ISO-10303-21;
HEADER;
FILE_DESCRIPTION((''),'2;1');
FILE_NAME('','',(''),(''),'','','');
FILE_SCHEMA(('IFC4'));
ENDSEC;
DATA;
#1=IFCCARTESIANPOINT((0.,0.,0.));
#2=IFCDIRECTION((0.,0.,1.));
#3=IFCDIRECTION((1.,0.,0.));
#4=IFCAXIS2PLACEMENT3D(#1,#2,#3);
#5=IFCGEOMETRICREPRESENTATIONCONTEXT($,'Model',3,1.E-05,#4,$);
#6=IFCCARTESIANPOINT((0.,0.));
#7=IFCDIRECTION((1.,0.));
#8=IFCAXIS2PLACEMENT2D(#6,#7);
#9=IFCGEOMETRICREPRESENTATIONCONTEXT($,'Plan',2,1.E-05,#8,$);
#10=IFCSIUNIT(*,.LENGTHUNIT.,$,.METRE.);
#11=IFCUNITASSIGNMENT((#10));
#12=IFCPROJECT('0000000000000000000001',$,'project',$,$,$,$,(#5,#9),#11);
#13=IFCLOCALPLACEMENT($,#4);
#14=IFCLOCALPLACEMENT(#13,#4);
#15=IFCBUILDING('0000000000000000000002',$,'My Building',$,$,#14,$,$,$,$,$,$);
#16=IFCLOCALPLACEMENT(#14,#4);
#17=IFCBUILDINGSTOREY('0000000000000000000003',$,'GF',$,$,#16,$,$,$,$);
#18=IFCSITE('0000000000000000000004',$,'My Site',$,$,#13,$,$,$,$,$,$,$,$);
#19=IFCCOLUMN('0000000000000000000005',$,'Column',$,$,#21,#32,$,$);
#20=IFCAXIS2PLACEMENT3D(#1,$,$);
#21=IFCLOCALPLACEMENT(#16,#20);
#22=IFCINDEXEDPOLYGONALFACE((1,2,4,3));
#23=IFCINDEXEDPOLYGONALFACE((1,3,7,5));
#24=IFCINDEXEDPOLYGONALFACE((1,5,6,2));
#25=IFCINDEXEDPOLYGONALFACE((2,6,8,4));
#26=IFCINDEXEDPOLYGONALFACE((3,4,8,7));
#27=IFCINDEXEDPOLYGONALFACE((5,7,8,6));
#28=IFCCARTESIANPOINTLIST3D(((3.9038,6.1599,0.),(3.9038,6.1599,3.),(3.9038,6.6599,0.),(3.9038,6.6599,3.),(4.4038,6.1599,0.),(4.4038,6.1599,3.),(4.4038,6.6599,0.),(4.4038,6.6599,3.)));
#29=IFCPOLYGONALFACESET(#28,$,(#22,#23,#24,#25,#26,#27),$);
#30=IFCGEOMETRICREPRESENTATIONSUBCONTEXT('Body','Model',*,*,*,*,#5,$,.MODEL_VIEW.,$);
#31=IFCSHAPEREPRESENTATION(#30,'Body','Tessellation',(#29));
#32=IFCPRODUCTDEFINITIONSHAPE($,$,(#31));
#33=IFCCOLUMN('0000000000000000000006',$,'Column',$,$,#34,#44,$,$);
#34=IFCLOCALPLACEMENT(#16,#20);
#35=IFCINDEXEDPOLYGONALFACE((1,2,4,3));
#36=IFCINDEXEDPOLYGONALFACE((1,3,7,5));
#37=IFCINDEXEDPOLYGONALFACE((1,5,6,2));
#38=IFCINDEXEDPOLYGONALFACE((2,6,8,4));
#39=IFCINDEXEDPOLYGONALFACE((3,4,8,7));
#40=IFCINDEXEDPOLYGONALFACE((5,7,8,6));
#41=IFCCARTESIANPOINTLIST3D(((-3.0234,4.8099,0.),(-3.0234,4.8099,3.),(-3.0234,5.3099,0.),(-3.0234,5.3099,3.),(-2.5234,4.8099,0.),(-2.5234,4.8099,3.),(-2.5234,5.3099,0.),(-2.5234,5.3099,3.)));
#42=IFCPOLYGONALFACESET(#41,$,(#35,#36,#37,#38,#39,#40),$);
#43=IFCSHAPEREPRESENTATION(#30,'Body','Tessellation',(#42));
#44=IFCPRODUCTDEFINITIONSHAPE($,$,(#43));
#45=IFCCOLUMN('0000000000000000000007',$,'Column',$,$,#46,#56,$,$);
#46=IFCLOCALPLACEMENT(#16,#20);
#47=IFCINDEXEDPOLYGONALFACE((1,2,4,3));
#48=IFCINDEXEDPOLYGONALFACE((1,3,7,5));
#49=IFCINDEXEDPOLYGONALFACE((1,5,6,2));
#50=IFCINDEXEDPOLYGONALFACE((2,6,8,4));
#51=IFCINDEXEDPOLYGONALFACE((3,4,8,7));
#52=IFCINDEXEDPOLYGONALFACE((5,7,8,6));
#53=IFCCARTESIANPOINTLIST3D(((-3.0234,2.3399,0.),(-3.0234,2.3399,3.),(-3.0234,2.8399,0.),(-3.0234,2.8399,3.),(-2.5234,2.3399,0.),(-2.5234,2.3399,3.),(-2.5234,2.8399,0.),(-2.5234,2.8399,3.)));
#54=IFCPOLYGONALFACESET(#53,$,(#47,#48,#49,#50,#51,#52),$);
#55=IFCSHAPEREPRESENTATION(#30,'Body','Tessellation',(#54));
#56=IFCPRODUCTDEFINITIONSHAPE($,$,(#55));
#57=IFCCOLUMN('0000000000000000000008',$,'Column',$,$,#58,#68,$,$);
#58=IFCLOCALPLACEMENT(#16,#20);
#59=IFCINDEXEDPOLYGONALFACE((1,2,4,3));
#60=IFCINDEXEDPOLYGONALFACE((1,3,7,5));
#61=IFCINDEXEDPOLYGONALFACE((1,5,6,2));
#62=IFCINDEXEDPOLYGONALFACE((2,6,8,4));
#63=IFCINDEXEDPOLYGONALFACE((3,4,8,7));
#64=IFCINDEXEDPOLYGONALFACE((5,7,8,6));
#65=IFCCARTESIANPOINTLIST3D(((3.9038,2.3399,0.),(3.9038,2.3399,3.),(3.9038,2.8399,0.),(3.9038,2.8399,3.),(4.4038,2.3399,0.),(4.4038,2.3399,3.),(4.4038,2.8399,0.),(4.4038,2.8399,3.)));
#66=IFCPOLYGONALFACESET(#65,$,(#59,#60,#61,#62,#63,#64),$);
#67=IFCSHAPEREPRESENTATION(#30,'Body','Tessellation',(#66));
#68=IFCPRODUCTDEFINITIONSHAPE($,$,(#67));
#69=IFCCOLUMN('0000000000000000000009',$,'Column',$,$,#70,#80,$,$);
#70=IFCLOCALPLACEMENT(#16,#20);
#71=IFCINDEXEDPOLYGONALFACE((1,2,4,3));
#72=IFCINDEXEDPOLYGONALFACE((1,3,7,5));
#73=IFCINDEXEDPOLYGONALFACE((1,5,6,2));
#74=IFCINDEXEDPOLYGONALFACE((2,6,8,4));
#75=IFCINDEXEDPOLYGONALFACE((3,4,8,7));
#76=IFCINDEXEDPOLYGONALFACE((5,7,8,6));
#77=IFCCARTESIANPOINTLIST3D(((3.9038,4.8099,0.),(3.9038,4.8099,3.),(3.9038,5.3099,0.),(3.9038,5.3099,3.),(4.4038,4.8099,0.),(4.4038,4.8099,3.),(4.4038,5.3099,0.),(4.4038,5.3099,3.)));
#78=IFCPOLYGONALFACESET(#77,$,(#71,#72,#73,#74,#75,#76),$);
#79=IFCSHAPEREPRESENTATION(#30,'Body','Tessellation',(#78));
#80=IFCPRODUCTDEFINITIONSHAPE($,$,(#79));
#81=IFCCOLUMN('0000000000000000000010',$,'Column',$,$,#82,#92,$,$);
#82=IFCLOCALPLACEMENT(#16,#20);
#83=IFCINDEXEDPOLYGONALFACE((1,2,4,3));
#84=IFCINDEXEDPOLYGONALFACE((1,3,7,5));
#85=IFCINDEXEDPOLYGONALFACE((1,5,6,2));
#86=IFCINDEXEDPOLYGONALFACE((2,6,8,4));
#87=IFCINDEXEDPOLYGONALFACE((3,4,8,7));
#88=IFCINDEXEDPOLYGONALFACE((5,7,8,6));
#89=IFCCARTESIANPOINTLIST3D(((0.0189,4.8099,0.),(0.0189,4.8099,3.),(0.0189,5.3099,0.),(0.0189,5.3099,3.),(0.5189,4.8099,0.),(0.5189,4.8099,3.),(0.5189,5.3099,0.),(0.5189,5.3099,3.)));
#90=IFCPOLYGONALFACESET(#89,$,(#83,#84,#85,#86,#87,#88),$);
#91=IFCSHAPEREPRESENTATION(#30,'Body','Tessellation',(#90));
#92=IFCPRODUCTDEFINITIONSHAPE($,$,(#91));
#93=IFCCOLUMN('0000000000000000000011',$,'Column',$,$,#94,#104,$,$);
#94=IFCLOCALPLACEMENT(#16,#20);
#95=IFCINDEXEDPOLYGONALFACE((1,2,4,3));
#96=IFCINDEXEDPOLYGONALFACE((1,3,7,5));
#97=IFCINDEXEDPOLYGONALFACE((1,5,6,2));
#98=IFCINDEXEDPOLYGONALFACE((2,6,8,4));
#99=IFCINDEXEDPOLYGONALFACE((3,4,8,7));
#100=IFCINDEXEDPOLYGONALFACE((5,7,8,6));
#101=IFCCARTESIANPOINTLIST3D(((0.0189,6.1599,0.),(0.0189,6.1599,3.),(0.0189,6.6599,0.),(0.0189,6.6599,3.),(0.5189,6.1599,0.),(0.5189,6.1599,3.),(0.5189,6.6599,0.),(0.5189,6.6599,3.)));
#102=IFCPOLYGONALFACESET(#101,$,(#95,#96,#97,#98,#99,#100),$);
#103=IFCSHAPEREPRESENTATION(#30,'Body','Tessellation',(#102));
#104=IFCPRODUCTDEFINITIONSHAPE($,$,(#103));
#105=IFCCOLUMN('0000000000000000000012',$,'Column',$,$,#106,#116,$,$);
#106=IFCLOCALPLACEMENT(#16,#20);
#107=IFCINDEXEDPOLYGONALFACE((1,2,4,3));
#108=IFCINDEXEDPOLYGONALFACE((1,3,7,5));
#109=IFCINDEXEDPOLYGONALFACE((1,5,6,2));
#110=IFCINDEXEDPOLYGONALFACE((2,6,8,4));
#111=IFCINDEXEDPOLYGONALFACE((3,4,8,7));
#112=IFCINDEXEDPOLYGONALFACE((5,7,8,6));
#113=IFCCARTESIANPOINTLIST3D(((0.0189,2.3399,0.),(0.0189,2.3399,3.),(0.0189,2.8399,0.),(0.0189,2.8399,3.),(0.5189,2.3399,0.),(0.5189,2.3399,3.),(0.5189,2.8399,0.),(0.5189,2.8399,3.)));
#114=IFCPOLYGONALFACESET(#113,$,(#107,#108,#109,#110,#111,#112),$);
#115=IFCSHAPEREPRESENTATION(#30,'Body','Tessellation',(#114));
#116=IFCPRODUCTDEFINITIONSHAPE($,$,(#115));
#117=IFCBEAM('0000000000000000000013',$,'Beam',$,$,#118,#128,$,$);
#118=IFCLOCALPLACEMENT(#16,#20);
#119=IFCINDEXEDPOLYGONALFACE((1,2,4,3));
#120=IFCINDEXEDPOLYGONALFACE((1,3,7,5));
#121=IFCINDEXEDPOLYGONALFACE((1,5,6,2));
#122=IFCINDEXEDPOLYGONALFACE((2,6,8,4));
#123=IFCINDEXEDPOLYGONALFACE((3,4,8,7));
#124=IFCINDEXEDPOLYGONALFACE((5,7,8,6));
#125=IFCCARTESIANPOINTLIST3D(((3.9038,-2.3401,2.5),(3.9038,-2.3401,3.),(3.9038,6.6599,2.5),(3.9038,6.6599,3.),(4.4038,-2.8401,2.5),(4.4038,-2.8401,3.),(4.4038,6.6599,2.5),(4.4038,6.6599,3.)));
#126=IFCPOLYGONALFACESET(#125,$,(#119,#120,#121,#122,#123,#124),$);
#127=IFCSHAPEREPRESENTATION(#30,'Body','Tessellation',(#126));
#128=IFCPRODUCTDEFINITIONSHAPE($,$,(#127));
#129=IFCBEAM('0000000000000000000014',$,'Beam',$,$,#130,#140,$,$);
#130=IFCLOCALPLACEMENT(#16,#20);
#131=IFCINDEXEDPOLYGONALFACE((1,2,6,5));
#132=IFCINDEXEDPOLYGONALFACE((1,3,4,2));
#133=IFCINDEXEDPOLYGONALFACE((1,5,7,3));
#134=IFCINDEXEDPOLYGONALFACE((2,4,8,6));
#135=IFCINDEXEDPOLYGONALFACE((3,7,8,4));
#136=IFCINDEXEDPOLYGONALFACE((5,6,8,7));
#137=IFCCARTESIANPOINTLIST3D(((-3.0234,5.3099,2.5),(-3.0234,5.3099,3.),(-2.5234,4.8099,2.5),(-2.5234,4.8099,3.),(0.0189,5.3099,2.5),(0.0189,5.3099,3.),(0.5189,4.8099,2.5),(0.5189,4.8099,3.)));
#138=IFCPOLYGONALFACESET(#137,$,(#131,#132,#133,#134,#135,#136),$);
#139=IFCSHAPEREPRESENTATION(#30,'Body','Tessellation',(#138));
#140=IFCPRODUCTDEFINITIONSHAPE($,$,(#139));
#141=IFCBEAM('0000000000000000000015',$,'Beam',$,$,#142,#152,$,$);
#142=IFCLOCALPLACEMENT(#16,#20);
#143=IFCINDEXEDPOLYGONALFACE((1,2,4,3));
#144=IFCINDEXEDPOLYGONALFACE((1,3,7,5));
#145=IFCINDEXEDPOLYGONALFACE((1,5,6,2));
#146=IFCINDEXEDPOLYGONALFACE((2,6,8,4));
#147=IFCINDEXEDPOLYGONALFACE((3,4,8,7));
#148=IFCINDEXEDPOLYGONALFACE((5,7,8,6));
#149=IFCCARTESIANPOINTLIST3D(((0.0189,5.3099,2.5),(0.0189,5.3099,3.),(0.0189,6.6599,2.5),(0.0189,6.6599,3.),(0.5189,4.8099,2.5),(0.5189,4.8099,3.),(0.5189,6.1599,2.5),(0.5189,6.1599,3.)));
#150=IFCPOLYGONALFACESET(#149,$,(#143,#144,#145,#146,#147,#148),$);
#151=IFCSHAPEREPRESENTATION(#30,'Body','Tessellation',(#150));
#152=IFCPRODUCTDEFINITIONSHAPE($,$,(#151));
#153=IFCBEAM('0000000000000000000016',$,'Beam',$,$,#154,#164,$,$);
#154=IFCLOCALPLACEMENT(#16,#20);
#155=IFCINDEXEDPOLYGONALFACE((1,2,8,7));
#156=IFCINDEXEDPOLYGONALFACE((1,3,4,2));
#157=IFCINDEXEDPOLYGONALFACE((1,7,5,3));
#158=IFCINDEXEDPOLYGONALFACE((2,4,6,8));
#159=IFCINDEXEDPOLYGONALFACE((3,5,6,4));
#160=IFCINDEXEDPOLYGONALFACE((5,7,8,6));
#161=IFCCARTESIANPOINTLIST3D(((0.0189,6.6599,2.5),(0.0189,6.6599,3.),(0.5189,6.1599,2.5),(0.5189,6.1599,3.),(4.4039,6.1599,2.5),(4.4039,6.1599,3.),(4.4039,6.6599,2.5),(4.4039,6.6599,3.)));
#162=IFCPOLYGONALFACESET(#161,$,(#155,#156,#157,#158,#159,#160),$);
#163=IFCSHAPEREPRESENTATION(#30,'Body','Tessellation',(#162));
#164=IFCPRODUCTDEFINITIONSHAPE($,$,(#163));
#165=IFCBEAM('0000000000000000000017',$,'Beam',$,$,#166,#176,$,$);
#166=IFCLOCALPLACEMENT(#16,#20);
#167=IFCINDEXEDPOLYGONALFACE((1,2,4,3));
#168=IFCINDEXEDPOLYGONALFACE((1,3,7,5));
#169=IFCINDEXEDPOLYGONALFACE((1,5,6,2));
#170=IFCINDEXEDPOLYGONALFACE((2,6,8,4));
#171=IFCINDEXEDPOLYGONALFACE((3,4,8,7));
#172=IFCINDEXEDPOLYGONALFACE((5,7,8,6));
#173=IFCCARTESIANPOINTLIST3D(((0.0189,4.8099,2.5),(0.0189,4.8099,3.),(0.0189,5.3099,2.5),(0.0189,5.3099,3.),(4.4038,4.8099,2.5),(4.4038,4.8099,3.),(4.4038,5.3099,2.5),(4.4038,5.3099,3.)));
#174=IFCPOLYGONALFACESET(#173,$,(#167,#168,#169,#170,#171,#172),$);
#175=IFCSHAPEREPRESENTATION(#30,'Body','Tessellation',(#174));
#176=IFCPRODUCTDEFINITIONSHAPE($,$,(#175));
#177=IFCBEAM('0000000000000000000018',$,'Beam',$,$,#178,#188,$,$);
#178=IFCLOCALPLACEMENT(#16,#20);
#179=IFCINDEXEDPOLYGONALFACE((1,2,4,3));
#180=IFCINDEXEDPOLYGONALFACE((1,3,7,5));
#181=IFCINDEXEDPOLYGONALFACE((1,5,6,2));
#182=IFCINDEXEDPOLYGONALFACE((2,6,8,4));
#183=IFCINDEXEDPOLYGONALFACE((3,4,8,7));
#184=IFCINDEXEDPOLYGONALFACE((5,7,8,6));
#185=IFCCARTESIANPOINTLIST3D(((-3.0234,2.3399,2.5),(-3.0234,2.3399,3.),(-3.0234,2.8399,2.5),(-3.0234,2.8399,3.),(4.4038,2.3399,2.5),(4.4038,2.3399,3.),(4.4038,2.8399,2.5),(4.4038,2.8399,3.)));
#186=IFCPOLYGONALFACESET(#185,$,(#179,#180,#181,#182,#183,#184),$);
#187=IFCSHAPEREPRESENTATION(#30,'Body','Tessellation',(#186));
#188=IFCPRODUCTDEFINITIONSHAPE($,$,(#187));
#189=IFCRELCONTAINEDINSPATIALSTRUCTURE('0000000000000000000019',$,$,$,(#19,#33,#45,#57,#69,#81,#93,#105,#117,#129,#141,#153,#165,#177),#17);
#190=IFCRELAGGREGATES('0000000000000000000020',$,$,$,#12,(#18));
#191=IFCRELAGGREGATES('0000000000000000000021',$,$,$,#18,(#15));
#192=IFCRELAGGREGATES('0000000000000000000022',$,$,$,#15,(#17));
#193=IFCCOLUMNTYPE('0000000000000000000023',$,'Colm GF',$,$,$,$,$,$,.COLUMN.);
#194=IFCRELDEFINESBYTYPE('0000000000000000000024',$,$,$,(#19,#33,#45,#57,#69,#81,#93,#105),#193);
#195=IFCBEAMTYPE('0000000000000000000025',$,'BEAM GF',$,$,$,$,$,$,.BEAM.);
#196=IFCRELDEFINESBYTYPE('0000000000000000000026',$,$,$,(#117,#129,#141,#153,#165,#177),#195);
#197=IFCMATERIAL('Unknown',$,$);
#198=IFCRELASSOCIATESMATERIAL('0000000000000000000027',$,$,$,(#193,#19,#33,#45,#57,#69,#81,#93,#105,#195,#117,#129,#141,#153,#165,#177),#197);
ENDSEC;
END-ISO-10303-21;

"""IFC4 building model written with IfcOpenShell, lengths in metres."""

from ifc_helpers import new_model, si_unit, frame, origin_with_axes, origin_2d_with_axis, place, context, subcontext, project, spatial, rectangle, extrude, clip, halfspace, material, material_profile, profile_set, profile_usage, type_object, element, save


model = new_model("IFC4")

# Units and contexts
model_context = context("Model", 3, precision=1e-05, world=origin_with_axes())
plan_context = context("Plan", 2, precision=1e-05, world=origin_2d_with_axis())
body_context_1 = subcontext(model_context, "Body", "Model", "MODEL_VIEW")
ifc_project = project(units=[si_unit("LENGTHUNIT", "METRE")], contexts=[model_context, plan_context])

# Site, building, storey
site_placement = place(None, origin_with_axes())
site = spatial("IfcSite", under=ifc_project, at=site_placement, Name="My Site")
building_placement = place(site_placement, origin_with_axes())
building = spatial("IfcBuilding", under=site, at=building_placement, Name="My Building")
storey_placement = place(building_placement, origin_with_axes())
storey = spatial("IfcBuildingStorey", under=building, at=storey_placement, Name="GF")

# Columns
ifc_material = material(Name="Unknown")
ifc_material_profile_1 = material_profile(ifc_material, rectangle(XDim=0.5, YDim=0.5))
ifc_profile_set_1 = profile_set([ifc_material_profile_1])
ifc_profile_usage_1 = profile_usage(ifc_profile_set_1, cardinal=5)
column_type = type_object("IfcColumnType", Name="Colm GF", PredefinedType="COLUMN", material=ifc_profile_set_1)
column_1_placement = place(storey_placement, frame((4.1538, 6.4099, 0.0), z_axis=(0.0, 0.0, 1.0), x_axis=(1.0, 0.0, 0.0)))
element("IfcColumn", 1, at=column_1_placement, inside=storey, type_object=column_type, material=ifc_profile_usage_1, Name="Column", context=body_context_1, shape_type="SweptSolid", body=[
    extrude(rectangle(XDim=0.5, YDim=0.5), origin_with_axes(), (0.0, 0.0, 1.0), 3.0),
])
ifc_profile_usage_2 = profile_usage(ifc_profile_set_1, cardinal=5)
column_2_placement = place(storey_placement, frame((-2.7734, 5.0599, 0.0), z_axis=(0.0, 0.0, 1.0), x_axis=(1.0, 0.0, 0.0)))
element("IfcColumn", 2, at=column_2_placement, inside=storey, type_object=column_type, material=ifc_profile_usage_2, Name="Column", context=body_context_1, shape_type="SweptSolid", body=[
    extrude(rectangle(XDim=0.5, YDim=0.5), origin_with_axes(), (0.0, 0.0, 1.0), 3.0),
])
ifc_profile_usage_3 = profile_usage(ifc_profile_set_1, cardinal=5)
column_3_placement = place(storey_placement, frame((-2.7734, 2.5899, 0.0), z_axis=(0.0, 0.0, 1.0), x_axis=(1.0, 0.0, 0.0)))
element("IfcColumn", 3, at=column_3_placement, inside=storey, type_object=column_type, material=ifc_profile_usage_3, Name="Column", context=body_context_1, shape_type="SweptSolid", body=[
    extrude(rectangle(XDim=0.5, YDim=0.5), origin_with_axes(), (0.0, 0.0, 1.0), 3.0),
])
ifc_profile_usage_4 = profile_usage(ifc_profile_set_1, cardinal=5)
column_4_placement = place(storey_placement, frame((4.1538, 2.5899, 0.0), z_axis=(0.0, 0.0, 1.0), x_axis=(1.0, 0.0, 0.0)))
element("IfcColumn", 4, at=column_4_placement, inside=storey, type_object=column_type, material=ifc_profile_usage_4, Name="Column", context=body_context_1, shape_type="SweptSolid", body=[
    extrude(rectangle(XDim=0.5, YDim=0.5), origin_with_axes(), (0.0, 0.0, 1.0), 3.0),
])
ifc_profile_usage_5 = profile_usage(ifc_profile_set_1, cardinal=5)
column_5_placement = place(storey_placement, frame((4.1538, 5.0599, 0.0), z_axis=(0.0, 0.0, 1.0), x_axis=(1.0, 0.0, 0.0)))
element("IfcColumn", 5, at=column_5_placement, inside=storey, type_object=column_type, material=ifc_profile_usage_5, Name="Column", context=body_context_1, shape_type="SweptSolid", body=[
    extrude(rectangle(XDim=0.5, YDim=0.5), origin_with_axes(), (0.0, 0.0, 1.0), 3.0),
])
ifc_profile_usage_6 = profile_usage(ifc_profile_set_1, cardinal=5)
column_6_placement = place(storey_placement, frame((0.2689, 5.0599, 0.0), z_axis=(0.0, 0.0, 1.0), x_axis=(1.0, 0.0, 0.0)))
element("IfcColumn", 6, at=column_6_placement, inside=storey, type_object=column_type, material=ifc_profile_usage_6, Name="Column", context=body_context_1, shape_type="SweptSolid", body=[
    extrude(rectangle(XDim=0.5, YDim=0.5), origin_with_axes(), (0.0, 0.0, 1.0), 3.0),
])
ifc_profile_usage_7 = profile_usage(ifc_profile_set_1, cardinal=5)
column_7_placement = place(storey_placement, frame((0.2689, 6.4099, 0.0), z_axis=(0.0, 0.0, 1.0), x_axis=(1.0, 0.0, 0.0)))
element("IfcColumn", 7, at=column_7_placement, inside=storey, type_object=column_type, material=ifc_profile_usage_7, Name="Column", context=body_context_1, shape_type="SweptSolid", body=[
    extrude(rectangle(XDim=0.5, YDim=0.5), origin_with_axes(), (0.0, 0.0, 1.0), 3.0),
])
ifc_profile_usage_8 = profile_usage(ifc_profile_set_1, cardinal=5)
column_8_placement = place(storey_placement, frame((0.2689, 2.5899, 0.0), z_axis=(0.0, 0.0, 1.0), x_axis=(1.0, 0.0, 0.0)))
element("IfcColumn", 8, at=column_8_placement, inside=storey, type_object=column_type, material=ifc_profile_usage_8, Name="Column", context=body_context_1, shape_type="SweptSolid", body=[
    extrude(rectangle(XDim=0.5, YDim=0.5), origin_with_axes(), (0.0, 0.0, 1.0), 3.0),
])

# Beams
ifc_material_profile_2 = material_profile(ifc_material, rectangle(XDim=0.5, YDim=0.5))
ifc_profile_set_2 = profile_set([ifc_material_profile_2])
ifc_profile_usage_9 = profile_usage(ifc_profile_set_2, cardinal=7)
beam_type = type_object("IfcBeamType", Name="BEAM GF", PredefinedType="BEAM", material=ifc_profile_set_2)
beam_1_placement = place(storey_placement, frame((4.4038, 6.6599, 3.0), z_axis=(0.0, -1.0, 0.0), x_axis=(1.0, 0.0, 0.0)))
element("IfcBeam", 9, at=beam_1_placement, inside=storey, type_object=beam_type, material=ifc_profile_usage_9, Name="Beam", context=body_context_1, shape_type="Clipping", body=[
    clip(extrude(rectangle(XDim=0.5, YDim=0.5), frame((-0.25, -0.25, 0.0), z_axis=(0.0, 0.0, 1.0), x_axis=(1.0, 0.0, 0.0)), (0.0, 0.0, 1.0), 9.5), halfspace(frame((0.0, -3.0, 9.5), z_axis=(-0.707107, 0.0, 0.707107), x_axis=(0.0, 1.0, 0.0)), False)),
])
ifc_profile_usage_10 = profile_usage(ifc_profile_set_2, cardinal=7)
beam_2_placement = place(storey_placement, frame((-3.0234, 5.3099, 3.0), z_axis=(1.0, 0.0, 0.000001), x_axis=(0.0, 1.0, 0.0)))
element("IfcBeam", 10, at=beam_2_placement, inside=storey, type_object=beam_type, material=ifc_profile_usage_10, Name="Beam", context=body_context_1, shape_type="Clipping", body=[
    clip(clip(extrude(rectangle(XDim=0.5, YDim=0.5), frame((-0.25, -0.25, 0.0), z_axis=(0.0, 0.0, 1.0), x_axis=(1.0, 0.0, 0.0)), (0.0, 0.0, 1.0), 3.5422), halfspace(frame((-0.5, -3.0, 3.5422), z_axis=(0.707107, 0.0, 0.707107), x_axis=(-0.000001, -1.0, 0.0)), False)), halfspace(frame((0.0, -3.0, 0.0), z_axis=(-0.707107, 0.0, -0.707107), x_axis=(0.000001, 1.0, 0.0)), False)),
])
ifc_profile_usage_11 = profile_usage(ifc_profile_set_2, cardinal=7)
beam_3_placement = place(storey_placement, frame((0.0189, 4.8099, 3.0), z_axis=(0.0, 1.0, 0.0), x_axis=(-1.0, 0.0, 0.0)))
element("IfcBeam", 11, at=beam_3_placement, inside=storey, type_object=beam_type, material=ifc_profile_usage_11, Name="Beam", context=body_context_1, shape_type="Clipping", body=[
    clip(clip(extrude(rectangle(XDim=0.5, YDim=0.5), frame((-0.25, -0.25, 0.0), z_axis=(0.0, 0.0, 1.0), x_axis=(1.0, 0.0, 0.0)), (0.0, 0.0, 1.0), 1.85), halfspace(frame((0.0, -3.0, 1.85), z_axis=(-0.707107, 0.0, 0.707107), x_axis=(0.0, 1.0, 0.0)), False)), halfspace(frame((-0.5, -3.0, 0.0), z_axis=(0.707107, 0.0, -0.707107), x_axis=(0.0, -1.0, 0.0)), False)),
])
ifc_profile_usage_12 = profile_usage(ifc_profile_set_2, cardinal=7)
beam_4_placement = place(storey_placement, frame((0.0189, 6.6599, 3.0), z_axis=(1.0, 0.0, 0.0), x_axis=(0.0, 1.0, 0.0)))
element("IfcBeam", 12, at=beam_4_placement, inside=storey, type_object=beam_type, material=ifc_profile_usage_12, Name="Beam", context=body_context_1, shape_type="Clipping", body=[
    clip(extrude(rectangle(XDim=0.5, YDim=0.5), frame((-0.25, -0.25, 0.0), z_axis=(0.0, 0.0, 1.0), x_axis=(1.0, 0.0, 0.0)), (0.0, 0.0, 1.0), 4.385), halfspace(frame((0.0, -3.0, 0.0), z_axis=(-0.707107, 0.0, -0.707107), x_axis=(0.0, 1.0, 0.0)), False)),
])
ifc_profile_usage_13 = profile_usage(ifc_profile_set_2, cardinal=7)
beam_5_placement = place(storey_placement, frame((4.4038, 4.8099, 3.0), z_axis=(-1.0, 0.0, 0.0), x_axis=(0.0, -1.0, 0.0)))
element("IfcBeam", 13, at=beam_5_placement, inside=storey, type_object=beam_type, material=ifc_profile_usage_13, Name="Beam", context=body_context_1, shape_type="SweptSolid", body=[
    extrude(rectangle(XDim=0.5, YDim=0.5), frame((-0.25, -0.25, 0.0), z_axis=(0.0, 0.0, 1.0), x_axis=(1.0, 0.0, 0.0)), (0.0, 0.0, 1.0), 4.3849),
])
ifc_profile_usage_14 = profile_usage(ifc_profile_set_2, cardinal=7)
beam_6_placement = place(storey_placement, frame((4.4038, 2.3399, 3.0), z_axis=(-1.0, -0.000001, 0.0), x_axis=(0.000001, -1.0, 0.0)))
element("IfcBeam", 14, at=beam_6_placement, inside=storey, type_object=beam_type, material=ifc_profile_usage_14, Name="Beam", context=body_context_1, shape_type="SweptSolid", body=[
    extrude(rectangle(XDim=0.5, YDim=0.5), frame((-0.25, -0.25, 0.0), z_axis=(0.0, 0.0, 1.0), x_axis=(1.0, 0.0, 0.0)), (0.0, 0.0, 1.0), 7.4272),
])

save(model, "model.ifc")
